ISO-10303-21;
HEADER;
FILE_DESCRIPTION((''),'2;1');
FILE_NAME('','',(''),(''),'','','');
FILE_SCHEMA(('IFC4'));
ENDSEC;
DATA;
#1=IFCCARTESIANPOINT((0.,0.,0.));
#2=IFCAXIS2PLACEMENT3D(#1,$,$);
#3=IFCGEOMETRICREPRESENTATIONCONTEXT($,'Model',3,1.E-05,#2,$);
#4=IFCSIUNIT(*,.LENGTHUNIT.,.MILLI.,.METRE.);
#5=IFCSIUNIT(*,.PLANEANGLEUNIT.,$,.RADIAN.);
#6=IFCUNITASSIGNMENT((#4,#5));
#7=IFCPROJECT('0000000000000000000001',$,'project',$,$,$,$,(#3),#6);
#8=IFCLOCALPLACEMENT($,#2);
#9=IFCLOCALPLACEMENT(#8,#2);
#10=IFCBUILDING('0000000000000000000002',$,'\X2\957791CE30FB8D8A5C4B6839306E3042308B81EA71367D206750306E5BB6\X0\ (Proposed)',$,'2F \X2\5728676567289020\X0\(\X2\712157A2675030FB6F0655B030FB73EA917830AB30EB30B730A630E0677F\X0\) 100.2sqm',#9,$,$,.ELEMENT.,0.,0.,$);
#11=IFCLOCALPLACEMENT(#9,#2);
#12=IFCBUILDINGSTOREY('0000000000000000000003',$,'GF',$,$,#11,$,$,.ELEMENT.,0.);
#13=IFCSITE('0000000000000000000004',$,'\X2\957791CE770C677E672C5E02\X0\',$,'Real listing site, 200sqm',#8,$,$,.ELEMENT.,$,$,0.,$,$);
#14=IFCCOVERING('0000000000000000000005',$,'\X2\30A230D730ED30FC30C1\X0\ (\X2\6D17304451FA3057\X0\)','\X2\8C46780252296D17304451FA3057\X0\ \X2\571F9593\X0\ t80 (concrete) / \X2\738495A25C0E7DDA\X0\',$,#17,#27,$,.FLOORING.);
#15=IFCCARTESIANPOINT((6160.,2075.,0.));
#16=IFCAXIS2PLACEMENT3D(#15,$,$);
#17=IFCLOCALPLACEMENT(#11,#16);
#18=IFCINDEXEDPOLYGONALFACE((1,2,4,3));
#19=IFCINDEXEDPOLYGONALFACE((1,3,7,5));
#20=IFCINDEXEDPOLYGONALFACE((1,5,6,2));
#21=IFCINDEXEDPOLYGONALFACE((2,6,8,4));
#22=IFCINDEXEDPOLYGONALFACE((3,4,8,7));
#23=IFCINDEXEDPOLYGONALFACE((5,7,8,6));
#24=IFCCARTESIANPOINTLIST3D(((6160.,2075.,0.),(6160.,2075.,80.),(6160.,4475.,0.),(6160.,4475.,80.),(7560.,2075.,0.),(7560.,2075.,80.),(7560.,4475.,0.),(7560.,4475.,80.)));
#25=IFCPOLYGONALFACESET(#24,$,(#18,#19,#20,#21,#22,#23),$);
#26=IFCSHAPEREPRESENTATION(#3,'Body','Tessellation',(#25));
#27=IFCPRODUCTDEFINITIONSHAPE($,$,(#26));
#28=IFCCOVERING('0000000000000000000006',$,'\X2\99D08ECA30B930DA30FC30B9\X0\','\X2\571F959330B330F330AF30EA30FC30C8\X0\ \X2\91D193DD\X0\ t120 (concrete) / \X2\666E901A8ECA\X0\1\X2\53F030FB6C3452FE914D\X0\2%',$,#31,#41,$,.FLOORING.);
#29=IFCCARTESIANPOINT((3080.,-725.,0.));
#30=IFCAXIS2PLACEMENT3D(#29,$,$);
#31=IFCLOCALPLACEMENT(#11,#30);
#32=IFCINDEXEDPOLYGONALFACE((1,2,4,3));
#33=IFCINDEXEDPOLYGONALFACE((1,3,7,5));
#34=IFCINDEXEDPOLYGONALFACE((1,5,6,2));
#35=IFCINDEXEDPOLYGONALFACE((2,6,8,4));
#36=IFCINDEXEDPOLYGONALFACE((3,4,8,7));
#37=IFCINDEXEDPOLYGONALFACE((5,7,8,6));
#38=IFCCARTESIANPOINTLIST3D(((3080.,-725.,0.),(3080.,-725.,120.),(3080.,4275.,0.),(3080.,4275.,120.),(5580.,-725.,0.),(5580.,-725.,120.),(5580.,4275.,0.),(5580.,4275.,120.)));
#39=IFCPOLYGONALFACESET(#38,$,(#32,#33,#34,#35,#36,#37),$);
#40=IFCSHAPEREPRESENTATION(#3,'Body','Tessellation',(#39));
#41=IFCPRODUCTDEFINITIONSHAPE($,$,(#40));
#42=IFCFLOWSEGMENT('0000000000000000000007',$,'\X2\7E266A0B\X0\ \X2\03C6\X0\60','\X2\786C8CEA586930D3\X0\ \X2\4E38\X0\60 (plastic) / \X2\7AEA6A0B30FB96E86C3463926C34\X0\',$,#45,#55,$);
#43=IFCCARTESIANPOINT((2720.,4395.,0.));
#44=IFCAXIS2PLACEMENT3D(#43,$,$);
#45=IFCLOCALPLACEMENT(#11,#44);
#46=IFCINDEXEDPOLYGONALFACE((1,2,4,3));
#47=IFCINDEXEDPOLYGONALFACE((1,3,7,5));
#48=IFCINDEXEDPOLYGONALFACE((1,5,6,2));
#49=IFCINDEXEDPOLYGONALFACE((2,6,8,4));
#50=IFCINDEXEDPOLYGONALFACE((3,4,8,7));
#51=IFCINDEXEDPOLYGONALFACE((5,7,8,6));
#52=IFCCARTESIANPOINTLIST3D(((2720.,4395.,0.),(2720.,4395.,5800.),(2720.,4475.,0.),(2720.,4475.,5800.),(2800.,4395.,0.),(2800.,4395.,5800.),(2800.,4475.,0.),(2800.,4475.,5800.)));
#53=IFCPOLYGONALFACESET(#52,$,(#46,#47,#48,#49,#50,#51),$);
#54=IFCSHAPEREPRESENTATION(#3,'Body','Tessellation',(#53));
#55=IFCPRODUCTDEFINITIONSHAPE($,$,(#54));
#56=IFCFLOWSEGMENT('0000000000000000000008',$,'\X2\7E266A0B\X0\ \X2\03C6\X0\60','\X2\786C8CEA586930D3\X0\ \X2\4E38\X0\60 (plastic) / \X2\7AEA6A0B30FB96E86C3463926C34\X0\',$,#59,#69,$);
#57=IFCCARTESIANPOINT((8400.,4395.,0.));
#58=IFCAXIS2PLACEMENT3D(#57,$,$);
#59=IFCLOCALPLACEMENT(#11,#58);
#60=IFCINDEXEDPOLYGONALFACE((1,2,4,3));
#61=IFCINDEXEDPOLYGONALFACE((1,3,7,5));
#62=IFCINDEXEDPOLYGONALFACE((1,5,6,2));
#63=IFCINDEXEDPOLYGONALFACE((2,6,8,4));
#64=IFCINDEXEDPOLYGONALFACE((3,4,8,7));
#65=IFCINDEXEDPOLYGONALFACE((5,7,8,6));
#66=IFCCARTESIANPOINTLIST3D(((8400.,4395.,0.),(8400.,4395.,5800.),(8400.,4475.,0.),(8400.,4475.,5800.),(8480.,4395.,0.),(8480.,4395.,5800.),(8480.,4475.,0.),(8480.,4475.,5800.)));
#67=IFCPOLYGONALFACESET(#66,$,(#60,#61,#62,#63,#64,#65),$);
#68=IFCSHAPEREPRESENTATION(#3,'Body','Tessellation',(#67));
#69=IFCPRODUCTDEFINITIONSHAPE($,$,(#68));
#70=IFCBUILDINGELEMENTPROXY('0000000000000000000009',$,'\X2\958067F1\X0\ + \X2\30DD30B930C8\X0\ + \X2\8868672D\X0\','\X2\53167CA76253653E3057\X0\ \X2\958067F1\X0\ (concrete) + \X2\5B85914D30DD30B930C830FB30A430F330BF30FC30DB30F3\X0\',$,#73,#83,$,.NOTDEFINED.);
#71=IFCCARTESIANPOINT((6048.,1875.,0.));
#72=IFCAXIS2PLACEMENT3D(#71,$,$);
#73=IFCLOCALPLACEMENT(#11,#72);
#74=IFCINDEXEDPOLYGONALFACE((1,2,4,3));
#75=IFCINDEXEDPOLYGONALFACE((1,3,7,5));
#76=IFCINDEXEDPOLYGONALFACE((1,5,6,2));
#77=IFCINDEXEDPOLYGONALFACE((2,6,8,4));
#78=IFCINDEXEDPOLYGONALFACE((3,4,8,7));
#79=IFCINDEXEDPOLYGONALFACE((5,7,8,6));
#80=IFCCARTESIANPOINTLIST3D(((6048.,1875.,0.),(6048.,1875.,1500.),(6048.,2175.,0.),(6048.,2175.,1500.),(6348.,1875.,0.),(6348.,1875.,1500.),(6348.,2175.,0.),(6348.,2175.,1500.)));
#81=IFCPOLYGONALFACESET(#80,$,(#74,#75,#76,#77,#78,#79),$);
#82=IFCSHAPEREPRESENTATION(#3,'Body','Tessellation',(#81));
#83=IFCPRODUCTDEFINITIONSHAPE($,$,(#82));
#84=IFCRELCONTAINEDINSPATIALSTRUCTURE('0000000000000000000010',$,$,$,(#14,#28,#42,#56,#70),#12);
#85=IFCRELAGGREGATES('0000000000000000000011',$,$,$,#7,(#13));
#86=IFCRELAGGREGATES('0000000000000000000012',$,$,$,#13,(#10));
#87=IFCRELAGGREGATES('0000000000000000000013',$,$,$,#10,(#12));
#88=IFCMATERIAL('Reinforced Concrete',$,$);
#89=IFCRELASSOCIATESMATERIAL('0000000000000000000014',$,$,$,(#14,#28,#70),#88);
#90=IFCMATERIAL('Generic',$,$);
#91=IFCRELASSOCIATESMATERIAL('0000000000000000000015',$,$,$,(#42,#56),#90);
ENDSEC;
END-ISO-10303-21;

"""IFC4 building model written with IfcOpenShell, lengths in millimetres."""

from ifc_helpers import new_model, si_unit, frame, frame_2d, origin, place, context, project, spatial, rectangle, extrude, material, element, save


model = new_model("IFC4")

# Units and contexts
model_context = context("Model", 3, precision=1e-05, world=origin())
ifc_project = project(units=[si_unit("LENGTHUNIT", "METRE", prefix="MILLI"), si_unit("PLANEANGLEUNIT", "RADIAN")], contexts=[model_context])

# Site, building, storey
site_placement = place(None, origin())
site = spatial("IfcSite", under=ifc_project, at=site_placement, Name="長野県松本市", ObjectType="Real listing site, 200sqm", CompositionType="ELEMENT", RefElevation=0.0)
building_placement = place(site_placement, origin())
building = spatial("IfcBuilding", under=site, at=building_placement, Name="長野・越屋根のある自然素材の家 (Proposed)", ObjectType="2F 在来木造(無垢材・漆喰・珪酸カルシウム板) 100.2sqm", CompositionType="ELEMENT", ElevationOfRefHeight=0.0, ElevationOfTerrain=0.0)
storey_placement = place(building_placement, origin())
storey = spatial("IfcBuildingStorey", under=building, at=storey_placement, Name="GF", CompositionType="ELEMENT", Elevation=0.0)

# Shared definitions
ifc_material_1 = material(Name="Reinforced Concrete")

# Coverings
covering_1_placement = place(storey_placement, frame((6160.0, 2075.0, 0.0)))
element("IfcCovering", 1, at=covering_1_placement, inside=storey, material=ifc_material_1, Name="アプローチ (洗い出し)", Description="豆砂利洗い出し 土間 t80 (concrete) / 玄関導線", PredefinedType="FLOORING", context=model_context, shape_type="SweptSolid", body=[
    extrude(rectangle(XDim=1400.0, YDim=2400.0, at=frame_2d((700.0, 1200.0))), frame((6160.0, 2075.0, 0.0)), (0.0, 0.0, 1.0), 80.0),
])
covering_2_placement = place(storey_placement, frame((3080.0, -725.0, 0.0)))
element("IfcCovering", 2, at=covering_2_placement, inside=storey, material=ifc_material_1, Name="駐車スペース", Description="土間コンクリート 金鏝 t120 (concrete) / 普通車1台・水勾配2%", PredefinedType="FLOORING", context=model_context, shape_type="SweptSolid", body=[
    extrude(rectangle(XDim=2500.0, YDim=5000.0, at=frame_2d((1250.0, 2500.0))), frame((3080.0, -725.0, 0.0)), (0.0, 0.0, 1.0), 120.0),
])

# Flow segments
ifc_material_2 = material(Name="Generic")
flow_segment_1_placement = place(storey_placement, frame((2720.0, 4395.0, 0.0)))
element("IfcFlowSegment", 3, at=flow_segment_1_placement, inside=storey, material=ifc_material_2, Name="縦樋 φ60", Description="硬質塩ビ 丸60 (plastic) / 竪樋・雨水排水", context=model_context, shape_type="SweptSolid", body=[
    extrude(rectangle(XDim=80.0, YDim=80.0, at=frame_2d((40.0, 40.0))), frame((2720.0, 4395.0, 0.0)), (0.0, 0.0, 1.0), 5800.0),
])
flow_segment_2_placement = place(storey_placement, frame((8400.0, 4395.0, 0.0)))
element("IfcFlowSegment", 4, at=flow_segment_2_placement, inside=storey, material=ifc_material_2, Name="縦樋 φ60", Description="硬質塩ビ 丸60 (plastic) / 竪樋・雨水排水", context=model_context, shape_type="SweptSolid", body=[
    extrude(rectangle(XDim=80.0, YDim=80.0, at=frame_2d((40.0, 40.0))), frame((8400.0, 4395.0, 0.0)), (0.0, 0.0, 1.0), 5800.0),
])

# Building element proxy
proxy_placement = place(storey_placement, frame((6048.0, 1875.0, 0.0)))
element("IfcBuildingElementProxy", 5, at=proxy_placement, inside=storey, material=ifc_material_1, Name="門柱 + ポスト + 表札", Description="化粧打放し 門柱 (concrete) + 宅配ポスト・インターホン", PredefinedType="NOTDEFINED", context=model_context, shape_type="SweptSolid", body=[
    extrude(rectangle(XDim=300.0, YDim=300.0, at=frame_2d((150.0, 150.0))), frame((6048.0, 1875.0, 0.0)), (0.0, 0.0, 1.0), 1500.0),
])

save(model, "model.ifc")
